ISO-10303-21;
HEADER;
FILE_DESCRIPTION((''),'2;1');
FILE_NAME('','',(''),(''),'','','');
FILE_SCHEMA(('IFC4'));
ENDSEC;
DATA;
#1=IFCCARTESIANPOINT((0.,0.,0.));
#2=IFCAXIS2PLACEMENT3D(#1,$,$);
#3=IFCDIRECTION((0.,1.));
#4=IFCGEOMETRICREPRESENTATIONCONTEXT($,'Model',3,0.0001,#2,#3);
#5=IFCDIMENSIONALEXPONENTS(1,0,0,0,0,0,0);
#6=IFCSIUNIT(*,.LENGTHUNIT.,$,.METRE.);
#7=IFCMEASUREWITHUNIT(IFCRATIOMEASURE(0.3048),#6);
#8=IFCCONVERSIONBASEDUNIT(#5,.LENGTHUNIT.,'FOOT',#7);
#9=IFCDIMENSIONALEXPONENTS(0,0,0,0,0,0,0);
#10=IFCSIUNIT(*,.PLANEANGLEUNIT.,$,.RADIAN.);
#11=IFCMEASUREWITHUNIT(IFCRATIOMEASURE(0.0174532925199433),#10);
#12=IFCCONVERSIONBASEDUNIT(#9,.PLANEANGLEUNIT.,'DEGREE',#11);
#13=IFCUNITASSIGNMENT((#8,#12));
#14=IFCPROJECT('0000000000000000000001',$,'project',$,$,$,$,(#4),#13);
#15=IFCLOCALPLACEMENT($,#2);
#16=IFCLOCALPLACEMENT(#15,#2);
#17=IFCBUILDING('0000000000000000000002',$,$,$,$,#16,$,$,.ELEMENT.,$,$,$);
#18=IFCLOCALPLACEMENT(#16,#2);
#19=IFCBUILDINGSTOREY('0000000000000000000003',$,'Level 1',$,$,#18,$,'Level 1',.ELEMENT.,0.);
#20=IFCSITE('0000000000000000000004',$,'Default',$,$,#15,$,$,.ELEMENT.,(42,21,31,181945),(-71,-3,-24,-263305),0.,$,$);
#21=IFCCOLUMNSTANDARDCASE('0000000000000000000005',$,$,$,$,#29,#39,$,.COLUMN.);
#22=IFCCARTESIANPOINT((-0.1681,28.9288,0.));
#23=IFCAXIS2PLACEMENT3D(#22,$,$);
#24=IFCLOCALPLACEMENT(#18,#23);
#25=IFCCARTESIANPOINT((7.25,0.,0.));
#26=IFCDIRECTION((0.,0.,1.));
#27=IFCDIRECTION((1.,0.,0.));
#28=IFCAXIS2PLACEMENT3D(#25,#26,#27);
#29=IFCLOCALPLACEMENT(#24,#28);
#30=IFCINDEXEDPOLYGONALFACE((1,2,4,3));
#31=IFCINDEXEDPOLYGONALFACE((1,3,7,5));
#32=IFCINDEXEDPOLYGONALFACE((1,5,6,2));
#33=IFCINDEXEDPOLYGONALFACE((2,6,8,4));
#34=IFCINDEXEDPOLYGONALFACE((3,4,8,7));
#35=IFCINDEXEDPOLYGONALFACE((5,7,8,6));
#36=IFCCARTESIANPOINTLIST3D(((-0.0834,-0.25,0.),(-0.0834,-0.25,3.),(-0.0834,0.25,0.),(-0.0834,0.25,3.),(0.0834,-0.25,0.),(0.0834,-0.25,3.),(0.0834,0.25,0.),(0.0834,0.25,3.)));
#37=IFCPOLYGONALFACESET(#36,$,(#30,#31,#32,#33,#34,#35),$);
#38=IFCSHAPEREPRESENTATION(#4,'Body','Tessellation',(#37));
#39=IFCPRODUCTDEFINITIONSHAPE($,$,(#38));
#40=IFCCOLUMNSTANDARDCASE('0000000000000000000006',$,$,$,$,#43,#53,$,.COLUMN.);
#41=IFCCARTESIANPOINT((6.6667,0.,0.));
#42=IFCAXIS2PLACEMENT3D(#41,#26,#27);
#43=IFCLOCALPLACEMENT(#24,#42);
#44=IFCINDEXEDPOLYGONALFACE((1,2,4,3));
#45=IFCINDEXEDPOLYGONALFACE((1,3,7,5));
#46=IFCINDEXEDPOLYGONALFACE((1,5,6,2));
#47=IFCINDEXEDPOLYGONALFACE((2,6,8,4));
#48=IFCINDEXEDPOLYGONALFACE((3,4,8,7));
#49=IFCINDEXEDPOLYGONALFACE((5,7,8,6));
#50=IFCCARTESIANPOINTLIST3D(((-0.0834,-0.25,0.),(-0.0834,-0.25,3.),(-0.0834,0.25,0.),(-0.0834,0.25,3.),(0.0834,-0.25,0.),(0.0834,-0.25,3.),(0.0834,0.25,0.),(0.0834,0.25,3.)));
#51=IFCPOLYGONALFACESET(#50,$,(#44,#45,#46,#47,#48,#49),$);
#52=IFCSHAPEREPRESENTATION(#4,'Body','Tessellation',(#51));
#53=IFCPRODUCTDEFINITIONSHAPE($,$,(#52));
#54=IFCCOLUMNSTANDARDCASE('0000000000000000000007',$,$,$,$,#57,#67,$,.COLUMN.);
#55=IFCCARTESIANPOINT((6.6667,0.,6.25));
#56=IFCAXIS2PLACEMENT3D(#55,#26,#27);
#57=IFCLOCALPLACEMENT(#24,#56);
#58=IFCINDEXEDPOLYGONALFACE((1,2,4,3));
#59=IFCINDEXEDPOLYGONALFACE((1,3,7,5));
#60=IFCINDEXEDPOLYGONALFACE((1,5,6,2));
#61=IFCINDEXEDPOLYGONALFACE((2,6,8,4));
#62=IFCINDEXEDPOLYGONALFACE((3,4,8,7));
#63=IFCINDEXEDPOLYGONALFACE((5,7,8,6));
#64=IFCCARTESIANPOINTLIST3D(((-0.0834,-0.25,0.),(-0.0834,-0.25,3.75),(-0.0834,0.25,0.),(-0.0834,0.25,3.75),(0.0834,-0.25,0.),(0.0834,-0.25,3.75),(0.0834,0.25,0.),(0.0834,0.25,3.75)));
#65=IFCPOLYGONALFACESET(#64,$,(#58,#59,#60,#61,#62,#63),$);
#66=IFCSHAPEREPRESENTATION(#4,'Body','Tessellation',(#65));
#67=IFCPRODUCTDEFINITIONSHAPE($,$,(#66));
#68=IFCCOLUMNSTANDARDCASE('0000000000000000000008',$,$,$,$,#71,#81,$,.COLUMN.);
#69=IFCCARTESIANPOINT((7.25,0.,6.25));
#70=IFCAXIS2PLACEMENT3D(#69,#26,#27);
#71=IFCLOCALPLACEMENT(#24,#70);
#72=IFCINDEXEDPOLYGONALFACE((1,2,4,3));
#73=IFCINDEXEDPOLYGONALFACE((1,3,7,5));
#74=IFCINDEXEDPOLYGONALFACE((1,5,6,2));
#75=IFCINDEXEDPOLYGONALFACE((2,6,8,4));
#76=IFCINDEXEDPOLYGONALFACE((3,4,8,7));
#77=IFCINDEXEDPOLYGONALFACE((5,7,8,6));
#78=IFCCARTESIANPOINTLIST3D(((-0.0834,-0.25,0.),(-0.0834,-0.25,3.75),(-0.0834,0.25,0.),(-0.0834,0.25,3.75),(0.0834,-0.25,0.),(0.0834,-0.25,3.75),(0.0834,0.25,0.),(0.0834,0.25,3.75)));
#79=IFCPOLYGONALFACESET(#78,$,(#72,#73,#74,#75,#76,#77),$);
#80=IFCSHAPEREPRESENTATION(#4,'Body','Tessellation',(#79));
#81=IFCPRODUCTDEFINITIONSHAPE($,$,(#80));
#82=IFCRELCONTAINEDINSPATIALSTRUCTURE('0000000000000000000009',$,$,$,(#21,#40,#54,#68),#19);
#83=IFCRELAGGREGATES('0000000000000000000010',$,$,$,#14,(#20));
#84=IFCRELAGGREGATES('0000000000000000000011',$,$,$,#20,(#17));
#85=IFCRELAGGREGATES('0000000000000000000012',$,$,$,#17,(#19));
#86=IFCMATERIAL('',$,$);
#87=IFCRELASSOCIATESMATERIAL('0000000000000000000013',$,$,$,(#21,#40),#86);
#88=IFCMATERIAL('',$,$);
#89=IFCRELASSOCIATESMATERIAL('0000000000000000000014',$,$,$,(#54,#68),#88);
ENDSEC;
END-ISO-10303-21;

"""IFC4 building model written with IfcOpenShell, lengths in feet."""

from ifc_helpers import new_model, entity, si_unit, converted_unit, direction, frame, origin, place, context, project, spatial, rectangle, extrude, material, element, save


model = new_model("IFC4")

# Units and contexts
model_context = context("Model", 3, precision=0.0001, world=origin(), true_north=direction((0.0, 1.0)))
ifc_project = project(units=[converted_unit("LENGTHUNIT", "FOOT", entity("IfcRatioMeasure", 0.3048), si_unit("LENGTHUNIT", "METRE"), dimensions=[1, 0, 0, 0, 0, 0, 0]), converted_unit("PLANEANGLEUNIT", "DEGREE", entity("IfcRatioMeasure", 0.0174532925199433), si_unit("PLANEANGLEUNIT", "RADIAN"), dimensions=[0, 0, 0, 0, 0, 0, 0])], contexts=[model_context])

# Site, building, storey
site_placement = place(None, origin())
site = spatial("IfcSite", under=ifc_project, at=site_placement, Name="Default", CompositionType="ELEMENT", RefLatitude=(42, 21, 31, 181945), RefLongitude=(-71, -3, -24, -263305), RefElevation=0.0)
building_placement = place(site_placement, origin())
building = spatial("IfcBuilding", under=site, at=building_placement, CompositionType="ELEMENT")
storey_placement = place(building_placement, origin())
storey = spatial("IfcBuildingStorey", under=building, at=storey_placement, Name="Level 1", LongName="Level 1", CompositionType="ELEMENT", Elevation=0.0)

# Columns
ifc_material_1 = material(Name="")
placement_1 = place(storey_placement, frame((-0.1681, 28.9288, 0.0)))
for number, where, z_axis, x_axis in (
    (1, (7.25, 0.0, 0.0), (0.0, 0.0, 1.0), (1.0, 0.0, 0.0)),
    (2, (6.6667, 0.0, 0.0), (0.0, 0.0, 1.0), (1.0, 0.0, 0.0)),
):
    element("IfcColumnStandardCase", number, at=place(placement_1, frame(where, z_axis=z_axis, x_axis=x_axis)), inside=storey, material=ifc_material_1, PredefinedType="COLUMN", context=model_context, shape_type="SweptSolid", body=[
        extrude(rectangle(XDim=0.1667, YDim=0.5), origin(), (0.0, 0.0, 1.0), 3.0),
    ])
ifc_material_2 = material(Name="")
for number, where, z_axis, x_axis in (
    (3, (6.6667, 0.0, 6.25), (0.0, 0.0, 1.0), (1.0, 0.0, 0.0)),
    (4, (7.25, 0.0, 6.25), (0.0, 0.0, 1.0), (1.0, 0.0, 0.0)),
):
    element("IfcColumnStandardCase", number, at=place(placement_1, frame(where, z_axis=z_axis, x_axis=x_axis)), inside=storey, material=ifc_material_2, PredefinedType="COLUMN", context=model_context, shape_type="SweptSolid", body=[
        extrude(rectangle(XDim=0.1667, YDim=0.5), origin(), (0.0, 0.0, 1.0), 3.75),
    ])

save(model, "model.ifc")
